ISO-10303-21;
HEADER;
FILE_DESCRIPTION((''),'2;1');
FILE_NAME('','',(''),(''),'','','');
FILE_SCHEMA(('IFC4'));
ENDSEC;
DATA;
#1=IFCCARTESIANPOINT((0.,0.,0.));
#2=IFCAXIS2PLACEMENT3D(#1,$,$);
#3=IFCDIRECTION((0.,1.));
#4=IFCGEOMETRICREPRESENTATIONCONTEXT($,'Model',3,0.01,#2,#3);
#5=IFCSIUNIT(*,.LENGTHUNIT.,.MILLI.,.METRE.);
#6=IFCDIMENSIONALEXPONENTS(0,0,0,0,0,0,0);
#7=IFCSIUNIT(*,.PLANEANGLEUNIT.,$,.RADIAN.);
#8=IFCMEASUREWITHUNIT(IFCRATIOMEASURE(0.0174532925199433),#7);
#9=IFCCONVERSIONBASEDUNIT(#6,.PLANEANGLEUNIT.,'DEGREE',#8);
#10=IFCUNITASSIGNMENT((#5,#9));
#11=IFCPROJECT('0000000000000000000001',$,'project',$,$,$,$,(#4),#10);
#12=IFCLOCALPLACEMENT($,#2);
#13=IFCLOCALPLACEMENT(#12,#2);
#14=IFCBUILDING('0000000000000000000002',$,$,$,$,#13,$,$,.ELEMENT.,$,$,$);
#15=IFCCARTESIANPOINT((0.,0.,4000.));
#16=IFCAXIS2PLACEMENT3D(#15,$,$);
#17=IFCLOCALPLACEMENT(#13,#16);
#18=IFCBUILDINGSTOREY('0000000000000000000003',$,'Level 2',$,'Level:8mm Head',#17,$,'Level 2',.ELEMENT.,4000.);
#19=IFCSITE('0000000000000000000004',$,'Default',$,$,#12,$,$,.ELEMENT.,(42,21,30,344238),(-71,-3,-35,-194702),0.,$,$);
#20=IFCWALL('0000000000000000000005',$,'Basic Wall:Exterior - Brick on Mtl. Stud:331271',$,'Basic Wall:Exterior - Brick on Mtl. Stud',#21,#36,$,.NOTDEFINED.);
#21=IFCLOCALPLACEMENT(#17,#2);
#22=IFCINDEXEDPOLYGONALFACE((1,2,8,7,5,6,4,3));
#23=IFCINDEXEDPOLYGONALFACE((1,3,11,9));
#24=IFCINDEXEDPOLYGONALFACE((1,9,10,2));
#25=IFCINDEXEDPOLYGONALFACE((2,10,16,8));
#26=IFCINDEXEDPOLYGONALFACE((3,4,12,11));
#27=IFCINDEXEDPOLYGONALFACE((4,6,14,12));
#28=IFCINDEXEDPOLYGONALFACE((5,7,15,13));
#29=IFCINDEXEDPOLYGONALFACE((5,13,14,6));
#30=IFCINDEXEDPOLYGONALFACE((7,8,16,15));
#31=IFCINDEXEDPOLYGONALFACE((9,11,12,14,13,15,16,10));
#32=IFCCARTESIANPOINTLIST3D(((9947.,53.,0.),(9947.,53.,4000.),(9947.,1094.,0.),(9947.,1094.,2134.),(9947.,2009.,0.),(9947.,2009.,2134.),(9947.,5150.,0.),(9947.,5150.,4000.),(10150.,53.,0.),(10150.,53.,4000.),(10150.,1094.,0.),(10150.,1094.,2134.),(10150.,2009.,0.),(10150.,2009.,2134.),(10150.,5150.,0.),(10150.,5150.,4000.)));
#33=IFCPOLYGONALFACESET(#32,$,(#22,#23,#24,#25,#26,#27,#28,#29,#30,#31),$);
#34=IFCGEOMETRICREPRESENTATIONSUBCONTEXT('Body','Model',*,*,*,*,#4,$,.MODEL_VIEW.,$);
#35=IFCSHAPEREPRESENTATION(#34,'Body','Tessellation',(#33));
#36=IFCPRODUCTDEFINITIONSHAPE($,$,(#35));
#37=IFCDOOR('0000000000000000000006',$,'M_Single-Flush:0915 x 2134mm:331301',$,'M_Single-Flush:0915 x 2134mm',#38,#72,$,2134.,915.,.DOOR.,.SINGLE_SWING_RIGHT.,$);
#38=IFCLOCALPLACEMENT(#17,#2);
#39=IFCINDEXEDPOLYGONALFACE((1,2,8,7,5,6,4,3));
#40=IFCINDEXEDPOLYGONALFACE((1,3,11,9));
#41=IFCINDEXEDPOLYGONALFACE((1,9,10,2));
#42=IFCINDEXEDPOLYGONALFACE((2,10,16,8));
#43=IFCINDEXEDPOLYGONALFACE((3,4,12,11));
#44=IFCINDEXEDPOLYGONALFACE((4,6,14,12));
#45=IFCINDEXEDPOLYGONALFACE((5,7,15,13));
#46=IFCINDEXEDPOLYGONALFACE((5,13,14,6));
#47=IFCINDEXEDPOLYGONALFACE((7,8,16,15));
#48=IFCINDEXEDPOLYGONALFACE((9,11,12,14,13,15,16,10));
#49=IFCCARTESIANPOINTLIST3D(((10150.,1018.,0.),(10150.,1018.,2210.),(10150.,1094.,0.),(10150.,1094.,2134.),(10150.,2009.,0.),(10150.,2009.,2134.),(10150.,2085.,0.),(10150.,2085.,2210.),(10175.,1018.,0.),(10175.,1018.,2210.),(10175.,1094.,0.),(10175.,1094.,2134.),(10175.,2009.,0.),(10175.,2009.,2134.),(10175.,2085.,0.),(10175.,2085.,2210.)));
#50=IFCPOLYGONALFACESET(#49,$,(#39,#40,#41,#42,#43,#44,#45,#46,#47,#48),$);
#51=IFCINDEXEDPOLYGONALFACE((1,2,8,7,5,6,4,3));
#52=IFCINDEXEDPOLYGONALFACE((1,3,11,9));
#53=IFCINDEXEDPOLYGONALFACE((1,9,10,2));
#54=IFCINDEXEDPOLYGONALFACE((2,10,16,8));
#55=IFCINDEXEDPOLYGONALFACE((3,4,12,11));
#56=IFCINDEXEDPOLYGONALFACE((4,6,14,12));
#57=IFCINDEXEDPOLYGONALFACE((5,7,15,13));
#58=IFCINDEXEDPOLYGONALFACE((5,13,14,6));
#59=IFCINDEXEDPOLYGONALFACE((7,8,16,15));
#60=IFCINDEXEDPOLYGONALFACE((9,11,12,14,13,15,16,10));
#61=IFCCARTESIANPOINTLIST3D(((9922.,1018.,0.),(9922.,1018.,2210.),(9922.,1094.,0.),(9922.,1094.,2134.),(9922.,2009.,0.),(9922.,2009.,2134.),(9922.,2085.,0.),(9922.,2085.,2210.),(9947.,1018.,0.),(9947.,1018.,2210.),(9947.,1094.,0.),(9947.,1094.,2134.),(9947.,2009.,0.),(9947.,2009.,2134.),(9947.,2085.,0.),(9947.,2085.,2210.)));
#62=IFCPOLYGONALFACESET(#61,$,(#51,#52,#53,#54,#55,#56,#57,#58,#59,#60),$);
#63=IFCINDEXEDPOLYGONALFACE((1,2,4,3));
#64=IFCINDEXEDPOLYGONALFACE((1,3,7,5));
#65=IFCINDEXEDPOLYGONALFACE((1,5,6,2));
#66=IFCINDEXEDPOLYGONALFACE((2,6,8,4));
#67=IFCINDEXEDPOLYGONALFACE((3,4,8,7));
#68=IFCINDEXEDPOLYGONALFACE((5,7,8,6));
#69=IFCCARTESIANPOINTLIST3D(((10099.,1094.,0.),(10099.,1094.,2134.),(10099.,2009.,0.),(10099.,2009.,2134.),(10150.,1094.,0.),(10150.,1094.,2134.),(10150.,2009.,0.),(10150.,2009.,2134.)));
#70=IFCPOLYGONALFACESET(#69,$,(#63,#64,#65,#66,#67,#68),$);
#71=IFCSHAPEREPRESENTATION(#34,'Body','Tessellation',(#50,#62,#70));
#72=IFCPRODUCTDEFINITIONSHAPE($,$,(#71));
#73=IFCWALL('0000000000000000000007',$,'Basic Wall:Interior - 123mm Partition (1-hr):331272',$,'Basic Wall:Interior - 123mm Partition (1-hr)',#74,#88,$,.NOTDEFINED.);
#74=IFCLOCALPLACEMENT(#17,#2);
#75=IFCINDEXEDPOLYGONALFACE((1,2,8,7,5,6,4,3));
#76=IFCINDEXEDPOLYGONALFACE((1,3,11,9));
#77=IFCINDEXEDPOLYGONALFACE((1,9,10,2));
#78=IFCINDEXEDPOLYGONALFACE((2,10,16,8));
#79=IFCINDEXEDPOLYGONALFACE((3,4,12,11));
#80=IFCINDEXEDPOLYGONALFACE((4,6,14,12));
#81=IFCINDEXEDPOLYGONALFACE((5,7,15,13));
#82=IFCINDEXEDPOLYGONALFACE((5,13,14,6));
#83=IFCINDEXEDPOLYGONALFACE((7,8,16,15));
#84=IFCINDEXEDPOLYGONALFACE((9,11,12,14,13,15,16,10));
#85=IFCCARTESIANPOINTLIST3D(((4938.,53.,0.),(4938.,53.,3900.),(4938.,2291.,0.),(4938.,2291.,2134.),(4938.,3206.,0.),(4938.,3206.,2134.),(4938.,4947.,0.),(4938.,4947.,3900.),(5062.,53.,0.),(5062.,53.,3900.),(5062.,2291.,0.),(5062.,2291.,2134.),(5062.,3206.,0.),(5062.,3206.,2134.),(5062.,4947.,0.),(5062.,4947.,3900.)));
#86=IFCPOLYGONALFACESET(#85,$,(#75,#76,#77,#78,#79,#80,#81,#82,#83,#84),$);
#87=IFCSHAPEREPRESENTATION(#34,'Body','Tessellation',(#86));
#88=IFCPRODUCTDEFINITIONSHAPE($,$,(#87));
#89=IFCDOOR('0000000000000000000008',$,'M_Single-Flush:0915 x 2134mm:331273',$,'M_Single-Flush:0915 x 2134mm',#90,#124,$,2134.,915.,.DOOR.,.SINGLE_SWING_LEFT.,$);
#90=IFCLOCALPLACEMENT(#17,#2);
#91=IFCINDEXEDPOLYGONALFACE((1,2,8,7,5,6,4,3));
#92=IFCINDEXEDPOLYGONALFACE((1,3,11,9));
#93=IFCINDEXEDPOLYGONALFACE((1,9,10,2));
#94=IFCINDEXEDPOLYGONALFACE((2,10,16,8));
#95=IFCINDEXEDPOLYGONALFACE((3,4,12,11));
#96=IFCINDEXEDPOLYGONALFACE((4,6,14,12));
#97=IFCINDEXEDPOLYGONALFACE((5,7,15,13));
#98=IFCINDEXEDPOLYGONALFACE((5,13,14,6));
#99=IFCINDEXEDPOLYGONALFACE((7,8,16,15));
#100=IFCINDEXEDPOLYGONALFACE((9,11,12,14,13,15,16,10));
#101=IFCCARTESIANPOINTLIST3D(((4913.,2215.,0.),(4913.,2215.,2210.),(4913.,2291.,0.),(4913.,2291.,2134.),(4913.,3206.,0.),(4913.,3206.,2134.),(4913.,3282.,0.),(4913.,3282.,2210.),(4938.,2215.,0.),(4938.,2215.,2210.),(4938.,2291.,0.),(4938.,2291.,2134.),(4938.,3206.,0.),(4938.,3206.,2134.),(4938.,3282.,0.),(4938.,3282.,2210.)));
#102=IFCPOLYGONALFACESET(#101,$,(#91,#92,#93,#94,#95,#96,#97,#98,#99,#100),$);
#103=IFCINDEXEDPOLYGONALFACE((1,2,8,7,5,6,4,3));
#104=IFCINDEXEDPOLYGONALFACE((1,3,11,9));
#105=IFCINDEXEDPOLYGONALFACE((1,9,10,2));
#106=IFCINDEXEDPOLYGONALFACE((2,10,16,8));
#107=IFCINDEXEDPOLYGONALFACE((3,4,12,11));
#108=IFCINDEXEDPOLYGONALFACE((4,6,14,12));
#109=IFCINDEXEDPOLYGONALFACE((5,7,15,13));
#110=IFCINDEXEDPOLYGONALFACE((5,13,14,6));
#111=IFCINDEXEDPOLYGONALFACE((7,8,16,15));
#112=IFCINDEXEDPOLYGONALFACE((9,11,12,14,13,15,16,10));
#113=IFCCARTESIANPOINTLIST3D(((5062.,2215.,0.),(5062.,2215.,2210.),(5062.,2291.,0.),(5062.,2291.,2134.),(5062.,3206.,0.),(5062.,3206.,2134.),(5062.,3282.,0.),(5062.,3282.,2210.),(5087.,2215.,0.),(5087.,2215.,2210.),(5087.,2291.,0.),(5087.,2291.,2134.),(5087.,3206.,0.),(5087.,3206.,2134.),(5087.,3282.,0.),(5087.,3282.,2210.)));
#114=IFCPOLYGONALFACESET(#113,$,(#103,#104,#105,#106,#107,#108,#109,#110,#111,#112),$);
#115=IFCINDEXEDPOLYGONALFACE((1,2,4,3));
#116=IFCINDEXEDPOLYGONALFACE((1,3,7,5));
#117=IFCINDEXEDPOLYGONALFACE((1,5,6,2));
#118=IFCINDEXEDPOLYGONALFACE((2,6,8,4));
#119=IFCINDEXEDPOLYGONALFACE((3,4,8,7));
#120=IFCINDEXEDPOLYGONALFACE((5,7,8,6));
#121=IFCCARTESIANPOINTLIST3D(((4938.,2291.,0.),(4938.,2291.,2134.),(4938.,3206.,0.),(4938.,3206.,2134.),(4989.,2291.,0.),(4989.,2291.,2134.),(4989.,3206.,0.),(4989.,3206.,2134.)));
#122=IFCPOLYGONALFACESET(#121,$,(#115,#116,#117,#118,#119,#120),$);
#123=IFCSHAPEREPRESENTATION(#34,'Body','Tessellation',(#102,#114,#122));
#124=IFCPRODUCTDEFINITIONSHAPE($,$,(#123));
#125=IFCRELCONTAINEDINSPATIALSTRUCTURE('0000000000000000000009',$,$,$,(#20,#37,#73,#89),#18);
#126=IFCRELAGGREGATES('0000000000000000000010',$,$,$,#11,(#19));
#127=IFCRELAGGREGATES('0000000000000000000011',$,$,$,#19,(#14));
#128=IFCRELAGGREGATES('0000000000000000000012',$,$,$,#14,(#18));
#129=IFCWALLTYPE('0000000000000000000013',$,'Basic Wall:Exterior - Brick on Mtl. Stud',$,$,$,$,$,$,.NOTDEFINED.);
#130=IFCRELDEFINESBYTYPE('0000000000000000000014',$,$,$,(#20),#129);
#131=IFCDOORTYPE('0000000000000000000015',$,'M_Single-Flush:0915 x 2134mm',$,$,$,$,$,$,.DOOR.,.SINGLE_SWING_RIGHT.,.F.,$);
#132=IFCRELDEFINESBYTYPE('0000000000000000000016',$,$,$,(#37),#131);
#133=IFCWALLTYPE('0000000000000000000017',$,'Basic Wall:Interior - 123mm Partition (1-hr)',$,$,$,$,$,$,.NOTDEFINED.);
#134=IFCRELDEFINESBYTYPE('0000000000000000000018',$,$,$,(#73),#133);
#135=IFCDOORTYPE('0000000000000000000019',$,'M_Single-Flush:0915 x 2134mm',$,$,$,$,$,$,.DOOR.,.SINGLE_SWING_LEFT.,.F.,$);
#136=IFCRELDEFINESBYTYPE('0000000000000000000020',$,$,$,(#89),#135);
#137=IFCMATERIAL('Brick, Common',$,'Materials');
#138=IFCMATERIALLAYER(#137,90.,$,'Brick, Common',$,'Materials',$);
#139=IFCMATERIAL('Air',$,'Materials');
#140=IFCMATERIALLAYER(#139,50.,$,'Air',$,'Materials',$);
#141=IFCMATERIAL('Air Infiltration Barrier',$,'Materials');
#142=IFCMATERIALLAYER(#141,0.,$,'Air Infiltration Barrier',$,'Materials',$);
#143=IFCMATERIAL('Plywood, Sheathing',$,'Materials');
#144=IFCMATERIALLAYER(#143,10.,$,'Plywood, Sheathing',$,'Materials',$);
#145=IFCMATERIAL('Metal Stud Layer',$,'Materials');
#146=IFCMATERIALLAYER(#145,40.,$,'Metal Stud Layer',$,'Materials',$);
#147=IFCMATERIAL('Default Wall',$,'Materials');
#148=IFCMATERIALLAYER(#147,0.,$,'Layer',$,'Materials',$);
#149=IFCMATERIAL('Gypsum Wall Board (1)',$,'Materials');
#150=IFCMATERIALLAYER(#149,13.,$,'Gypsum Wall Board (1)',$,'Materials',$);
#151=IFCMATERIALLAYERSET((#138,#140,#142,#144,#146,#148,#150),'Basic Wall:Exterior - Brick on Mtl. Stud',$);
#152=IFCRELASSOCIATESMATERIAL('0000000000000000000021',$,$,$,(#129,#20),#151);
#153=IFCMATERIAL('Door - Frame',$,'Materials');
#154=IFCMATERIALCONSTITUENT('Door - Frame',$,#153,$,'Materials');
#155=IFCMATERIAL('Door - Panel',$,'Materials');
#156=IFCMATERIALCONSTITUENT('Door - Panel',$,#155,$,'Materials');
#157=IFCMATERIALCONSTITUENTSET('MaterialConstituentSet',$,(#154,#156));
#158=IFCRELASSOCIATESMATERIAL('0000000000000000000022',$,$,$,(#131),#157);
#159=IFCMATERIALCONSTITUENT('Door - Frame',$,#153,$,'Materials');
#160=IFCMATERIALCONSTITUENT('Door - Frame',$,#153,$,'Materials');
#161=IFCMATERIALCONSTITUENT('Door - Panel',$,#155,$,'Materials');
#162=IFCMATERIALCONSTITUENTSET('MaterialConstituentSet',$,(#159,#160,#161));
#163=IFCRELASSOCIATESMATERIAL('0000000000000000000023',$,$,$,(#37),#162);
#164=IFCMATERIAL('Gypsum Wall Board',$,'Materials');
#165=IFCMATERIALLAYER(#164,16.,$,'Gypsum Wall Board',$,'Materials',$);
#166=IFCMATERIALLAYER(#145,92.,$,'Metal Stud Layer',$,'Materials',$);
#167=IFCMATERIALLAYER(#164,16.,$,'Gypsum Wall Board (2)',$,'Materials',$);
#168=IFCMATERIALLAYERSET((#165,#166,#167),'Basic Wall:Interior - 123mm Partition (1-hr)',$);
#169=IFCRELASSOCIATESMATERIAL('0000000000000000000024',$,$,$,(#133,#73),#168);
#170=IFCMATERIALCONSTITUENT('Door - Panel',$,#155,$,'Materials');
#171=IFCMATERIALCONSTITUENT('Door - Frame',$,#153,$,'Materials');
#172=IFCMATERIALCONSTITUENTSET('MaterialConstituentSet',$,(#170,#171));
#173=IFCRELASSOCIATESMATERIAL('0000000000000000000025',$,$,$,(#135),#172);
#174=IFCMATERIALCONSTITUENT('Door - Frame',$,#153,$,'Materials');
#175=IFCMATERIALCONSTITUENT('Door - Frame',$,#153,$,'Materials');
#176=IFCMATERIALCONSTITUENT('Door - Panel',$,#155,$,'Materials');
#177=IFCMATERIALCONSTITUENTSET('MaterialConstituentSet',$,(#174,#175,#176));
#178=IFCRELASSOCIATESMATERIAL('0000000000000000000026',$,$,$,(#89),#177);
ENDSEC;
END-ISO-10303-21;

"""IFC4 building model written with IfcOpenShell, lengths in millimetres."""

from ifc_helpers import new_model, entity, si_unit, converted_unit, direction, frame, frame_2d, origin, origin_2d_with_axis, place, context, subcontext, project, spatial, polyline, rectangle, outline, extrude, source, transform, mapped, material, layer, layer_set, layer_usage, constituent, constituent_set, type_object, type_shapes, element, fill, save


model = new_model("IFC4")

# Units and contexts
model_context = context("Model", 3, precision=0.01, world=origin(), true_north=direction((0.0, 1.0)))
body_context = subcontext(model_context, "Body", "Model", "MODEL_VIEW")
ifc_project = project(units=[si_unit("LENGTHUNIT", "METRE", prefix="MILLI"), converted_unit("PLANEANGLEUNIT", "DEGREE", entity("IfcRatioMeasure", 0.0174532925199433), si_unit("PLANEANGLEUNIT", "RADIAN"), dimensions=[0, 0, 0, 0, 0, 0, 0])], contexts=[model_context])

# Site, building, storey
site_placement = place(None, origin())
site = spatial("IfcSite", under=ifc_project, at=site_placement, Name="Default", CompositionType="ELEMENT", RefLatitude=(42, 21, 30, 344238), RefLongitude=(-71, -3, -35, -194702), RefElevation=0.0)
building_placement = place(site_placement, origin())
building = spatial("IfcBuilding", under=site, at=building_placement, CompositionType="ELEMENT")
storey_placement = place(building_placement, frame((0.0, 0.0, 4000.0)))
storey = spatial("IfcBuildingStorey", under=building, at=storey_placement, Name="Level 2", ObjectType="Level:8mm Head", LongName="Level 2", CompositionType="ELEMENT", Elevation=4000.0)

# Shared definitions
ifc_material_1 = material(Name="Brick, Common", Category="Materials")
ifc_layer_1 = layer(ifc_material_1, 90.0, Name="Brick, Common", Category="Materials")
ifc_material_2 = material(Name="Air", Category="Materials")
ifc_layer_2 = layer(ifc_material_2, 50.0, Name="Air", Category="Materials")
ifc_material_3 = material(Name="Air Infiltration Barrier", Category="Materials")
ifc_layer_3 = layer(ifc_material_3, 0.0, Name="Air Infiltration Barrier", Category="Materials")
ifc_material_4 = material(Name="Plywood, Sheathing", Category="Materials")
ifc_layer_4 = layer(ifc_material_4, 10.0, Name="Plywood, Sheathing", Category="Materials")
ifc_material_5 = material(Name="Metal Stud Layer", Category="Materials")
ifc_layer_5 = layer(ifc_material_5, 40.0, Name="Metal Stud Layer", Category="Materials")
ifc_material_6 = material(Name="Default Wall", Category="Materials")
ifc_layer_6 = layer(ifc_material_6, 0.0, Name="Layer", Category="Materials")
ifc_material_7 = material(Name="Gypsum Wall Board (1)", Category="Materials")
ifc_layer_7 = layer(ifc_material_7, 13.0, Name="Gypsum Wall Board (1)", Category="Materials")
ifc_layer_set_1 = layer_set([ifc_layer_1, ifc_layer_2, ifc_layer_3, ifc_layer_4, ifc_layer_5, ifc_layer_6, ifc_layer_7], Name="Basic Wall:Exterior - Brick on Mtl. Stud")
wall_type_1 = type_object("IfcWallType", Name="Basic Wall:Exterior - Brick on Mtl. Stud", PredefinedType="NOTDEFINED", material=ifc_layer_set_1)

# Walls, openings, doors
ifc_layer_usage_1 = layer_usage(ifc_layer_set_1, "AXIS2", "NEGATIVE", 101.5)
wall_1_placement = place(storey_placement, frame((10048.5, 5150.0, 0.0), z_axis=(0.0, 0.0, 1.0), x_axis=(0.0, -1.0, 0.0)))
wall_1 = element("IfcWall", 1, at=wall_1_placement, inside=storey, type_object=wall_type_1, material=ifc_layer_usage_1, Name="Basic Wall:Exterior - Brick on Mtl. Stud:331271", ObjectType="Basic Wall:Exterior - Brick on Mtl. Stud", PredefinedType="NOTDEFINED", context=body_context, shape_type="SweptSolid", body=[
    extrude(rectangle(XDim=5097.0, YDim=203.0, at=frame_2d((2548.5, 0.0), x_axis=(-1.0, 0.0))), origin(), (0.0, 0.0, 1.0), 4000.0),
])
opening_1_placement = place(wall_1_placement, frame((3141.0, -101.5, 0.0)))
opening_1 = element("IfcOpeningElement", 2, at=opening_1_placement, cuts=wall_1, ObjectType="Opening", PredefinedType="OPENING", context=body_context, shape_type="SweptSolid", body=[
    extrude(rectangle(XDim=915.0, YDim=2134.0, at=frame_2d((1067.0, 457.5), x_axis=(0.0, 1.0))), frame((0.0, 0.0, 0.0), z_axis=(0.0, 1.0, 0.0), x_axis=(0.0, 0.0, 1.0)), (0.0, 0.0, 1.0), 203.0),
])
ifc_material_8 = material(Name="Door - Frame", Category="Materials")
ifc_constituent_1 = constituent(ifc_material_8, Name="Door - Frame", Category="Materials")
ifc_constituent_2 = constituent(ifc_material_8, Name="Door - Frame", Category="Materials")
ifc_material_9 = material(Name="Door - Panel", Category="Materials")
ifc_constituent_3 = constituent(ifc_material_9, Name="Door - Panel", Category="Materials")
ifc_constituent_set_1 = constituent_set(constituents=[ifc_constituent_1, ifc_constituent_2, ifc_constituent_3], Name="MaterialConstituentSet")
ifc_constituent_4 = constituent(ifc_material_8, Name="Door - Frame", Category="Materials")
ifc_constituent_5 = constituent(ifc_material_9, Name="Door - Panel", Category="Materials")
ifc_constituent_set_2 = constituent_set(constituents=[ifc_constituent_4, ifc_constituent_5], Name="MaterialConstituentSet")
door_type_1 = type_object("IfcDoorType", Name="M_Single-Flush:0915 x 2134mm", OperationType="SINGLE_SWING_RIGHT", ParameterTakesPrecedence=False, PredefinedType="DOOR", material=ifc_constituent_set_2)
shared_shape_1 = source(origin(), body_context, "Body", "SweptSolid", [
    extrude(outline(polyline([(-533.5, -1124.0), (533.5, -1124.0), (533.5, 1086.0), (457.5, 1086.0), (457.5, -1048.0), (-457.5, -1048.0), (-457.5, 1086.0), (-533.5, 1086.0), (-533.5, -1124.0)])), frame((457.5, 203.0, 1086.0), z_axis=(0.0, 1.0, 0.0), x_axis=(1.0, 0.0, 0.0)), (0.0, 0.0, 1.0), 25.0),
    extrude(outline(polyline([(-1124.0, -533.5), (1086.0, -533.5), (1086.0, -457.5), (-1048.0, -457.5), (-1048.0, 457.5), (1086.0, 457.5), (1086.0, 533.5), (-1124.0, 533.5), (-1124.0, -533.5)])), frame((457.5, -25.0, 1086.0), z_axis=(0.0, 1.0, 0.0), x_axis=(0.0, 0.0, -1.0)), (0.0, 0.0, 1.0), 25.0),
    extrude(rectangle(XDim=51.0, YDim=915.0, at=frame_2d((0.0, 0.0), x_axis=(1.0, 0.0))), frame((457.5, 177.5, 0.0), z_axis=(0.0, 0.0, 1.0), x_axis=(0.0, 1.0, 0.0)), (0.0, 0.0, 1.0), 2134.0),
])
type_shapes(door_type_1, [shared_shape_1])
door_1_placement = place(opening_1_placement, origin())
door_1 = element("IfcDoor", 3, at=door_1_placement, inside=storey, type_object=door_type_1, material=ifc_constituent_set_1, Name="M_Single-Flush:0915 x 2134mm:331301", ObjectType="M_Single-Flush:0915 x 2134mm", OperationType="SINGLE_SWING_RIGHT", OverallHeight=2134.0, OverallWidth=915.0, PredefinedType="DOOR", context=body_context, shape_type="MappedRepresentation", body=[
    mapped(shared_shape_1, transform((0.0, 0.0, 0.0), scale=1.0)),
])
fill(opening_1, door_1)
ifc_material_10 = material(Name="Gypsum Wall Board", Category="Materials")
ifc_layer_8 = layer(ifc_material_10, 16.0, Name="Gypsum Wall Board", Category="Materials")
ifc_layer_9 = layer(ifc_material_5, 92.0, Name="Metal Stud Layer", Category="Materials")
ifc_layer_10 = layer(ifc_material_10, 16.0, Name="Gypsum Wall Board (2)", Category="Materials")
ifc_layer_set_2 = layer_set([ifc_layer_8, ifc_layer_9, ifc_layer_10], Name="Basic Wall:Interior - 123mm Partition (1-hr)")
ifc_layer_usage_2 = layer_usage(ifc_layer_set_2, "AXIS2", "NEGATIVE", 62.0)
wall_type_2 = type_object("IfcWallType", Name="Basic Wall:Interior - 123mm Partition (1-hr)", PredefinedType="NOTDEFINED", material=ifc_layer_set_2)
wall_2_placement = place(storey_placement, frame((5000.0, 4947.0, 0.0), z_axis=(0.0, 0.0, 1.0), x_axis=(0.0, -1.0, 0.0)))
wall_2 = element("IfcWall", 4, at=wall_2_placement, inside=storey, type_object=wall_type_2, material=ifc_layer_usage_2, Name="Basic Wall:Interior - 123mm Partition (1-hr):331272", ObjectType="Basic Wall:Interior - 123mm Partition (1-hr)", PredefinedType="NOTDEFINED", context=body_context, shape_type="SweptSolid", body=[
    extrude(rectangle(XDim=4894.0, YDim=124.0, at=frame_2d((2447.0, 0.0), x_axis=(-1.0, 0.0))), origin(), (0.0, 0.0, 1.0), 3900.0),
])
opening_2_placement = place(wall_2_placement, frame((2656.0, 62.0, 0.0)))
opening_2 = element("IfcOpeningElement", 5, at=opening_2_placement, cuts=wall_2, ObjectType="Opening", PredefinedType="OPENING", context=body_context, shape_type="SweptSolid", body=[
    extrude(rectangle(XDim=915.0, YDim=2134.0, at=frame_2d((1067.0, 457.5), x_axis=(0.0, -1.0))), frame((0.0, 0.0, 0.0), z_axis=(0.0, -1.0, 0.0), x_axis=(0.0, 0.0, 1.0)), (0.0, 0.0, 1.0), 124.0),
])
ifc_constituent_6 = constituent(ifc_material_8, Name="Door - Frame", Category="Materials")
ifc_constituent_7 = constituent(ifc_material_8, Name="Door - Frame", Category="Materials")
ifc_constituent_8 = constituent(ifc_material_9, Name="Door - Panel", Category="Materials")
ifc_constituent_set_3 = constituent_set(constituents=[ifc_constituent_6, ifc_constituent_7, ifc_constituent_8], Name="MaterialConstituentSet")
ifc_constituent_9 = constituent(ifc_material_9, Name="Door - Panel", Category="Materials")
ifc_constituent_10 = constituent(ifc_material_8, Name="Door - Frame", Category="Materials")
ifc_constituent_set_4 = constituent_set(constituents=[ifc_constituent_9, ifc_constituent_10], Name="MaterialConstituentSet")
door_type_2 = type_object("IfcDoorType", Name="M_Single-Flush:0915 x 2134mm", OperationType="SINGLE_SWING_LEFT", ParameterTakesPrecedence=False, PredefinedType="DOOR", material=ifc_constituent_set_4)
shared_shape_2 = source(origin(), body_context, "Body", "SweptSolid", [
    extrude(outline(polyline([(-533.5, -1124.0), (533.5, -1124.0), (533.5, 1086.0), (457.5, 1086.0), (457.5, -1048.0), (-457.5, -1048.0), (-457.5, 1086.0), (-533.5, 1086.0), (-533.5, -1124.0)])), frame((457.5, 149.0, 1086.0), z_axis=(0.0, -1.0, 0.0), x_axis=(-1.0, 0.0, 0.0)), (0.0, 0.0, 1.0), 25.0),
    extrude(outline(polyline([(-1124.0, -533.5), (1086.0, -533.5), (1086.0, -457.5), (-1048.0, -457.5), (-1048.0, 457.5), (1086.0, 457.5), (1086.0, 533.5), (-1124.0, 533.5), (-1124.0, -533.5)])), frame((457.5, 0.0, 1086.0), z_axis=(0.0, -1.0, 0.0), x_axis=(0.0, 0.0, -1.0)), (0.0, 0.0, 1.0), 25.0),
    extrude(rectangle(XDim=915.0, YDim=51.0, at=origin_2d_with_axis()), frame((457.5, 98.5, 0.0)), (0.0, 0.0, 1.0), 2134.0),
])
type_shapes(door_type_2, [shared_shape_2])
door_2_placement = place(opening_2_placement, frame((0.0, 0.0, 0.0), z_axis=(0.0, 0.0, 1.0), x_axis=(-1.0, 0.0, 0.0)))
door_2 = element("IfcDoor", 6, at=door_2_placement, inside=storey, type_object=door_type_2, material=ifc_constituent_set_3, Name="M_Single-Flush:0915 x 2134mm:331273", ObjectType="M_Single-Flush:0915 x 2134mm", OperationType="SINGLE_SWING_LEFT", OverallHeight=2134.0, OverallWidth=915.0, PredefinedType="DOOR", context=body_context, shape_type="MappedRepresentation", body=[
    mapped(shared_shape_2, transform((0.0, 0.0, 0.0), scale=1.0)),
])
fill(opening_2, door_2)

save(model, "model.ifc")
